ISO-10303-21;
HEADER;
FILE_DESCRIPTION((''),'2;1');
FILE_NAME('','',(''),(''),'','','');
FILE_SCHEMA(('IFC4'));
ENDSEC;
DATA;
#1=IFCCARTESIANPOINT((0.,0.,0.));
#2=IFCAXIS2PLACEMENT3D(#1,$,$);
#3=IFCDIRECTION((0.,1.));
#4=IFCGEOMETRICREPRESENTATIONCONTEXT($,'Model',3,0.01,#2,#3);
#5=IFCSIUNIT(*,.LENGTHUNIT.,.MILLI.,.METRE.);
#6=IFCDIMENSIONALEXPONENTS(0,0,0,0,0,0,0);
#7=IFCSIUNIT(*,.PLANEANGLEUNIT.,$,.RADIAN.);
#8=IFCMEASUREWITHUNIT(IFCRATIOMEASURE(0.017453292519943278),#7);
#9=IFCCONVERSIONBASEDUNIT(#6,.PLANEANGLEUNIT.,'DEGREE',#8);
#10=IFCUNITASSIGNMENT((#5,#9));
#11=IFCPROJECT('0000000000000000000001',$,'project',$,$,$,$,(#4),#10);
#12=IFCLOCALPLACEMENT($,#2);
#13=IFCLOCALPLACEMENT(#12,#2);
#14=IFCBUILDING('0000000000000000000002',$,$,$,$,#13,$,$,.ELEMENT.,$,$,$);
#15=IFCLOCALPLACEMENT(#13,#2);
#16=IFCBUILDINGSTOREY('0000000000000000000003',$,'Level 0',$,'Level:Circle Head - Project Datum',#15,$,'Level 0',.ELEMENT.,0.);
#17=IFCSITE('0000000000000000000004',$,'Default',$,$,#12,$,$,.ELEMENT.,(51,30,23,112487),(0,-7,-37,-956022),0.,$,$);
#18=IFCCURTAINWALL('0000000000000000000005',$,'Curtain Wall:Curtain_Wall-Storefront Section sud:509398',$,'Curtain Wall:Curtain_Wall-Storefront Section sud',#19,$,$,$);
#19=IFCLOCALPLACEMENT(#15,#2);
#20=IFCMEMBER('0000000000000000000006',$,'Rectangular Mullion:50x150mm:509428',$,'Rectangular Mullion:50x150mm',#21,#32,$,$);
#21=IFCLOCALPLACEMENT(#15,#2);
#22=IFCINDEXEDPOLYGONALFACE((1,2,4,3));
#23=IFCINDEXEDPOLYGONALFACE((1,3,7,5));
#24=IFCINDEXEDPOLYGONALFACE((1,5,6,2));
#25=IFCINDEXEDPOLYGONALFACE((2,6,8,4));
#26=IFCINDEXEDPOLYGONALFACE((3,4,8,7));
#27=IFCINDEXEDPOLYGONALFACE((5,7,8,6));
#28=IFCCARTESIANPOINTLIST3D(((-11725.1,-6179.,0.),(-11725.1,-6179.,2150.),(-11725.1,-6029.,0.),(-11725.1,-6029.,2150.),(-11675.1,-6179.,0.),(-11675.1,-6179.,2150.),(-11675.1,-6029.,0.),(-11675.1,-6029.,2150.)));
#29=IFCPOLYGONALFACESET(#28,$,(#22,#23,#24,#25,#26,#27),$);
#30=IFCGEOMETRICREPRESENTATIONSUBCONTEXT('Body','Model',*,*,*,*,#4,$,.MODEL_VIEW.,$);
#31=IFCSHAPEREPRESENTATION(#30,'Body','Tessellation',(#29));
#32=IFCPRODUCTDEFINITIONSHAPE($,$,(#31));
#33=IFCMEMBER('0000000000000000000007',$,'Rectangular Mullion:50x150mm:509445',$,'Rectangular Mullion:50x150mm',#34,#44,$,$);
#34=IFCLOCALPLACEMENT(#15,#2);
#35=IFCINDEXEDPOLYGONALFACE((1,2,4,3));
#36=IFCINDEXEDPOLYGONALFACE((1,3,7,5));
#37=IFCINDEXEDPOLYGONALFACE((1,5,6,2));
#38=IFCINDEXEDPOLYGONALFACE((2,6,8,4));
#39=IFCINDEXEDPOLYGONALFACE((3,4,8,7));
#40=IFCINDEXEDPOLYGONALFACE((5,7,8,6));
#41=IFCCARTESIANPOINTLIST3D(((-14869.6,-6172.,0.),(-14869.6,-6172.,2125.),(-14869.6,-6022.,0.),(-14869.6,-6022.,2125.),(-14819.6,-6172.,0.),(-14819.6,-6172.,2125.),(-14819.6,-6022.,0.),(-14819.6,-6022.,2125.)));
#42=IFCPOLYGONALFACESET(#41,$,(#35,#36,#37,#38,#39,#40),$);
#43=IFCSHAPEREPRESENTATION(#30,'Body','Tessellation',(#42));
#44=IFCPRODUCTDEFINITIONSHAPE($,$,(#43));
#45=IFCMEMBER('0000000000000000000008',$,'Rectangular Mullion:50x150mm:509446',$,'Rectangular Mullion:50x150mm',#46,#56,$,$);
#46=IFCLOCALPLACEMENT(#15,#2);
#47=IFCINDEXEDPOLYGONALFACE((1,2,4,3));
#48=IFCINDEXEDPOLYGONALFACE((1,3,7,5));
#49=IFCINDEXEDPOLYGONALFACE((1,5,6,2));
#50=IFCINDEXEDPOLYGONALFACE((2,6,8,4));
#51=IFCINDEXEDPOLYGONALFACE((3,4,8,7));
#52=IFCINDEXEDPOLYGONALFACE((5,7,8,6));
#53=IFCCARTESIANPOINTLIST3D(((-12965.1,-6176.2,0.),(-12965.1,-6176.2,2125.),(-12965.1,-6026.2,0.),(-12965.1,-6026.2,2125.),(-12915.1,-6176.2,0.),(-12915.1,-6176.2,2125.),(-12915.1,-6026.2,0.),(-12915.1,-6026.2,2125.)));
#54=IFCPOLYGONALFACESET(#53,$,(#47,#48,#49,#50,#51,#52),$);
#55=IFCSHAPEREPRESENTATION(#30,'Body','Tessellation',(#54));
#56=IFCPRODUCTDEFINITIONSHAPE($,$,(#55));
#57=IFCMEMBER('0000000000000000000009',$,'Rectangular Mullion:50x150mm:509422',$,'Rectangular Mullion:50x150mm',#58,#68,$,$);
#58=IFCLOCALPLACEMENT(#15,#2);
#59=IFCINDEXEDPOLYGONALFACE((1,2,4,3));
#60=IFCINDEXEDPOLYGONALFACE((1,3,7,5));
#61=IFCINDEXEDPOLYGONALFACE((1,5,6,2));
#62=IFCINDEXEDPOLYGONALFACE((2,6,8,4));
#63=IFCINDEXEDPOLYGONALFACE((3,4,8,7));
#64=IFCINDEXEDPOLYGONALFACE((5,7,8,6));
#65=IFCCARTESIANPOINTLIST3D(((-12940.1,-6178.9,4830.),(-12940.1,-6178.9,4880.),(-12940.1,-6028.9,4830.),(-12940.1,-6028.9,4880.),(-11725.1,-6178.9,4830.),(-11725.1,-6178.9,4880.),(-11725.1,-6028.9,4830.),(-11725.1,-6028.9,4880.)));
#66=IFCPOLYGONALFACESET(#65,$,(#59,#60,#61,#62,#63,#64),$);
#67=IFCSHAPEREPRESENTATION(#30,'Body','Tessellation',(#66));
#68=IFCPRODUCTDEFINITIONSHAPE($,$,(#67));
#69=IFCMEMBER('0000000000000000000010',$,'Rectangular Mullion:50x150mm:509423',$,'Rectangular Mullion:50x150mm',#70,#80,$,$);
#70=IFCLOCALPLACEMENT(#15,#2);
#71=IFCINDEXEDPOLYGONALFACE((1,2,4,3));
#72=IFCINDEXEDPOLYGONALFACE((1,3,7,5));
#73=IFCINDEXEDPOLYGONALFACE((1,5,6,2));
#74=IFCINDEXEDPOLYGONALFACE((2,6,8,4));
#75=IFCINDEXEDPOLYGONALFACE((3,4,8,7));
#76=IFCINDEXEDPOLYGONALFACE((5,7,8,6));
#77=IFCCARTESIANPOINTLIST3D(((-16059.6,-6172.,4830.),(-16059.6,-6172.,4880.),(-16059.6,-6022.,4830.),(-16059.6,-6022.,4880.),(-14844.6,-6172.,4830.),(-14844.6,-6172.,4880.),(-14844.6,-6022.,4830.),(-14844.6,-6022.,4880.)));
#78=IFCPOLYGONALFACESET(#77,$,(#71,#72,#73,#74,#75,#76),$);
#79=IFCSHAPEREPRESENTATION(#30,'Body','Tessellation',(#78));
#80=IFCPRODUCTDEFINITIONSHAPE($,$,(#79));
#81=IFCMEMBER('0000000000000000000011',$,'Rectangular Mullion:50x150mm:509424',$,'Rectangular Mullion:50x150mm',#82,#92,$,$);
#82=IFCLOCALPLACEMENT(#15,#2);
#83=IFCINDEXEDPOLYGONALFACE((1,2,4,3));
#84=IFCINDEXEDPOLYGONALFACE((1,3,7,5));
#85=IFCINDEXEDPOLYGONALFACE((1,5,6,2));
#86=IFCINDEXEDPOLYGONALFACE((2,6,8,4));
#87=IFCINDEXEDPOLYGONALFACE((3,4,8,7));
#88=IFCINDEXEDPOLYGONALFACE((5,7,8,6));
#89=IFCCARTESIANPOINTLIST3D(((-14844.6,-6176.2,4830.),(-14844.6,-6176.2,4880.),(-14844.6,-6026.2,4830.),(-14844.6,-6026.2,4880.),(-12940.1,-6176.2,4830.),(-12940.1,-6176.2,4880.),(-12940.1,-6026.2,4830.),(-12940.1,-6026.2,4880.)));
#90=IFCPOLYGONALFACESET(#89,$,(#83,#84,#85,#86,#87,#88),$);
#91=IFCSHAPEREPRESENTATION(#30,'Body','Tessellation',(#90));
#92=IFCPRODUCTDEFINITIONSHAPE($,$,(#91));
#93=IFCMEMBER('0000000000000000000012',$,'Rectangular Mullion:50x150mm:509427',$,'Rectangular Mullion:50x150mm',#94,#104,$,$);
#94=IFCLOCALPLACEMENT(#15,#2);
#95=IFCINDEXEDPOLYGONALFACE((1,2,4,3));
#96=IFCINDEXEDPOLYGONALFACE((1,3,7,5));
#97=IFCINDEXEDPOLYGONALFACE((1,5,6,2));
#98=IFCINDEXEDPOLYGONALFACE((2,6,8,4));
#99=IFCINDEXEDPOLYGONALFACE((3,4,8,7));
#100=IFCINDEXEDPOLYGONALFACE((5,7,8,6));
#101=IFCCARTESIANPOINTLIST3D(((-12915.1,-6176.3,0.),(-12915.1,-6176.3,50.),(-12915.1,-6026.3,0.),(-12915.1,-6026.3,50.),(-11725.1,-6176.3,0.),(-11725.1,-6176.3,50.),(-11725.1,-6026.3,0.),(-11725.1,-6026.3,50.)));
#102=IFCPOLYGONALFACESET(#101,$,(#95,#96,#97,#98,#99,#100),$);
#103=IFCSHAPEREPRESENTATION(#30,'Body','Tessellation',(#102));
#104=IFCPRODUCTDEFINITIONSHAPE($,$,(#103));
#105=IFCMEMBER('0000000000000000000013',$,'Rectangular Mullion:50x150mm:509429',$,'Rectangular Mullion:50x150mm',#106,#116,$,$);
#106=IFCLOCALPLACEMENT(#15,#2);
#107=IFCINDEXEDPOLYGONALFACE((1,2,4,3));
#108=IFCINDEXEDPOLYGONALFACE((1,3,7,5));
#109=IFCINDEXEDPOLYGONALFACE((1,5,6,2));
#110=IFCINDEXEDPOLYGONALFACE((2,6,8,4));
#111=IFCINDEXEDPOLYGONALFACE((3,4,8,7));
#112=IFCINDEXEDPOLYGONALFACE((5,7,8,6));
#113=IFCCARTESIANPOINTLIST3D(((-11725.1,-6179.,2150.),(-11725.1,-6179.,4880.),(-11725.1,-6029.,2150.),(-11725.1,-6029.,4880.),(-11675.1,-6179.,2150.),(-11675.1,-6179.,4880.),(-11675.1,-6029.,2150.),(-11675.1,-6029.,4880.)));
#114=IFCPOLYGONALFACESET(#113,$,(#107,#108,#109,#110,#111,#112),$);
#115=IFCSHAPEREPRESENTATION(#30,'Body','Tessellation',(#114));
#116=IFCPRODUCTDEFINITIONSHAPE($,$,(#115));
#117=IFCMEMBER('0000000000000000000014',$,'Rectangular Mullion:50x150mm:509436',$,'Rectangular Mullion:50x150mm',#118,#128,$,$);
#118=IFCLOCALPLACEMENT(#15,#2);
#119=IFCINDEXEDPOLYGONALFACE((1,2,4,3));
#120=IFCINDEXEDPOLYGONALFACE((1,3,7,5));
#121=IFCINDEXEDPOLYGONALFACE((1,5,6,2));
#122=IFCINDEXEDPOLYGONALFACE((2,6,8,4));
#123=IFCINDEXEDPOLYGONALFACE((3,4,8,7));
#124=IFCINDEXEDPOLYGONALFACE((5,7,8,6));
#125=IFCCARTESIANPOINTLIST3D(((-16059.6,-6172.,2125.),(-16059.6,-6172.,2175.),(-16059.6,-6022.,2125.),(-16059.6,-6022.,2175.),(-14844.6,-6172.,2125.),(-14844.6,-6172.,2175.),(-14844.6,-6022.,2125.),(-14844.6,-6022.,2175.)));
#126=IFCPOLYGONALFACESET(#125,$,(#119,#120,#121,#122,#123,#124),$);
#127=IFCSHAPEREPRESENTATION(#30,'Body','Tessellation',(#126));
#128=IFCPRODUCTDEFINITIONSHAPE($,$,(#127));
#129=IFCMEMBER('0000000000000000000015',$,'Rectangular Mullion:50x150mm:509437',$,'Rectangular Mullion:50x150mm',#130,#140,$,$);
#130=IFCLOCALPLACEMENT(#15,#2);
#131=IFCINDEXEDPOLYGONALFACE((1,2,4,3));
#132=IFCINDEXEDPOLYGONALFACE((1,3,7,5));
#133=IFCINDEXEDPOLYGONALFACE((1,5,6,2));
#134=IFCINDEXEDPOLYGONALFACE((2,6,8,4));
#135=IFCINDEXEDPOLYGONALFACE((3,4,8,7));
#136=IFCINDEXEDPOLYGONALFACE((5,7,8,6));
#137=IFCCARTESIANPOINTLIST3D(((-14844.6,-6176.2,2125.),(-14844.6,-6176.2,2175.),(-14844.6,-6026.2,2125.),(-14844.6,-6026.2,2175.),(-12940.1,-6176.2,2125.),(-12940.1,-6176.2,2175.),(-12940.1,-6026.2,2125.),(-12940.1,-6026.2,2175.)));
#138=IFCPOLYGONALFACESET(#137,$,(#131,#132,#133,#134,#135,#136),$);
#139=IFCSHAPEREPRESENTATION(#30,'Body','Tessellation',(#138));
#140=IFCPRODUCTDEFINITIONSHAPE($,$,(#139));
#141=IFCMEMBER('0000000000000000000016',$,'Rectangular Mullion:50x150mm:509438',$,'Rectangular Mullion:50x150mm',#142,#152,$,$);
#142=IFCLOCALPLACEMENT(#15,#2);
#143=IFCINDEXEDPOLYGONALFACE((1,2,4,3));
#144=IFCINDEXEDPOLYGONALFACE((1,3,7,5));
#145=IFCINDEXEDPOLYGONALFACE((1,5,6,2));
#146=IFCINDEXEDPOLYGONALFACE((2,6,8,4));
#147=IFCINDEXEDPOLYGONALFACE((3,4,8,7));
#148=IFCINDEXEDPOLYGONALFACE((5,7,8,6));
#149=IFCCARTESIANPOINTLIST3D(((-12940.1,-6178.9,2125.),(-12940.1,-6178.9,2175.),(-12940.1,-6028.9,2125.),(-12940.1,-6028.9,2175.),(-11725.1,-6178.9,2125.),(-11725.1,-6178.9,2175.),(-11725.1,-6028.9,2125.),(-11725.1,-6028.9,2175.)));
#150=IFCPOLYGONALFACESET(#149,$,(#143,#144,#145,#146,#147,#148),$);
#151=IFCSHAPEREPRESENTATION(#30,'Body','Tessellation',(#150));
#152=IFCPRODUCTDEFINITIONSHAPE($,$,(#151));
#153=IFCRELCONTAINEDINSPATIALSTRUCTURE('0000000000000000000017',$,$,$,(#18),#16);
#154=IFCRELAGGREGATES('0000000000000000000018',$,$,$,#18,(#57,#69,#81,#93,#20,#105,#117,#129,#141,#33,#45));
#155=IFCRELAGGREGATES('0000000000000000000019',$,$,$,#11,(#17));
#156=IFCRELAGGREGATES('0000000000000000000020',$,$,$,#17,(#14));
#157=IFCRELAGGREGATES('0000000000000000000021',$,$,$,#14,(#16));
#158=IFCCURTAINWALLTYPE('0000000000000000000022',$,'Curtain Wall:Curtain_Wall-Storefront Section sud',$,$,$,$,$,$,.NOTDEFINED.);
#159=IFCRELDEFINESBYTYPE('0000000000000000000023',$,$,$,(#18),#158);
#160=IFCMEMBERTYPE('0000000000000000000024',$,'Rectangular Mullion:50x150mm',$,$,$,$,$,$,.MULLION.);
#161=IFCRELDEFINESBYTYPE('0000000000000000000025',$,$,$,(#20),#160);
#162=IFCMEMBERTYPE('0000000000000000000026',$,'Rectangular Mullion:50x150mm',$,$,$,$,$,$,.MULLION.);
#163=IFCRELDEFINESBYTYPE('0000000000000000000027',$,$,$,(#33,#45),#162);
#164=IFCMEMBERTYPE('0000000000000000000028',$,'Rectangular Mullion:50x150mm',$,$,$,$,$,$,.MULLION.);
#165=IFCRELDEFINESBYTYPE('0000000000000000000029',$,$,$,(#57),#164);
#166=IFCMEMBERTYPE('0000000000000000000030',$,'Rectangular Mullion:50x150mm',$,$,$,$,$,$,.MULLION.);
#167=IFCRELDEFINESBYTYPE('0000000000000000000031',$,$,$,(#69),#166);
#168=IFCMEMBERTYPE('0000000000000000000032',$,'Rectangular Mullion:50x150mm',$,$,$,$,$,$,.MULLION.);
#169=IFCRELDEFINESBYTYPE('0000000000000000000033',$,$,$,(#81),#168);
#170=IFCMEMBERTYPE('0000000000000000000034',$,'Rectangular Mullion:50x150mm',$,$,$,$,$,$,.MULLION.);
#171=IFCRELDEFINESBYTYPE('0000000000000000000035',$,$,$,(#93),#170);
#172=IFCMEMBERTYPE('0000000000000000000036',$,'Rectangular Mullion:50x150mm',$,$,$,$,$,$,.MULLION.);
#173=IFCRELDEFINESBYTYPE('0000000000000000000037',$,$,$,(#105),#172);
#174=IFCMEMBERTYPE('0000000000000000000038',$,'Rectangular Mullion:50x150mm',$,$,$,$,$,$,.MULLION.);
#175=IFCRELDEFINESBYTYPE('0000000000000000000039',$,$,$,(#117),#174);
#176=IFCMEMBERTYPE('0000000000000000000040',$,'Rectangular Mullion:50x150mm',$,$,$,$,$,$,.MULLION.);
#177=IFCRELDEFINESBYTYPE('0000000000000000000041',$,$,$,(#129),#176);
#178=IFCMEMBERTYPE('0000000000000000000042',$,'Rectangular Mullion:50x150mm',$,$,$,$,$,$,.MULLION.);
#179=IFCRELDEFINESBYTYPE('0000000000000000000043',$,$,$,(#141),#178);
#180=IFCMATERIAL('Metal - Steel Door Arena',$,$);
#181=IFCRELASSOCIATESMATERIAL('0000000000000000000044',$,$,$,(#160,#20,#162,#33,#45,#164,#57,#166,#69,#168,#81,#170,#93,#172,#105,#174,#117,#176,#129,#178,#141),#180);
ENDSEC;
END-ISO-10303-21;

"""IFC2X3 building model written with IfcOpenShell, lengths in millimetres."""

from ifc_helpers import new_model, entity, si_unit, converted_unit, direction, frame, origin, origin_2d_with_axis, place, context, subcontext, project, spatial, rectangle, extrude, source, transform, mapped, material, type_object, type_shapes, element, aggregate, save


model = new_model("IFC2X3")

# Units and contexts
model_context = context("Model", 3, precision=0.01, world=origin(), true_north=direction((0.0, 1.0)))
body_context = subcontext(model_context, "Body", "Model", "MODEL_VIEW")
ifc_project = project(units=[si_unit("LENGTHUNIT", "METRE", prefix="MILLI"), converted_unit("PLANEANGLEUNIT", "DEGREE", entity("IfcRatioMeasure", 0.017453292519943278), si_unit("PLANEANGLEUNIT", "RADIAN"), dimensions=[0, 0, 0, 0, 0, 0, 0])], contexts=[model_context])

# Site, building, storey
site_placement = place(None, origin())
site = spatial("IfcSite", under=ifc_project, at=site_placement, Name="Default", CompositionType="ELEMENT", RefLatitude=(51, 30, 23, 112487), RefLongitude=(0, -7, -37, -956022), RefElevation=0.0)
building_placement = place(site_placement, origin())
building = spatial("IfcBuilding", under=site, at=building_placement, CompositionType="ELEMENT")
storey_placement = place(building_placement, origin())
storey = spatial("IfcBuildingStorey", under=building, at=storey_placement, Name="Level 0", ObjectType="Level:Circle Head - Project Datum", LongName="Level 0", CompositionType="ELEMENT", Elevation=0.0)

# Curtain wall, members
curtain_wall_type = type_object("IfcCurtainWallType", Name="Curtain Wall:Curtain_Wall-Storefront Section sud", PredefinedType="NOTDEFINED")
curtain_wall_placement = place(storey_placement, origin())
curtain_wall = element("IfcCurtainWall", 1, at=curtain_wall_placement, inside=storey, type_object=curtain_wall_type, Name="Curtain Wall:Curtain_Wall-Storefront Section sud:509398", ObjectType="Curtain Wall:Curtain_Wall-Storefront Section sud")
ifc_material_1 = material(Name="Metal - Steel Door Arena")
member_type_1 = type_object("IfcMemberType", Name="Rectangular Mullion:50x150mm", PredefinedType="MULLION", material=ifc_material_1)
shared_shape_1 = source(origin(), body_context, "Body", "SweptSolid", [
    extrude(rectangle(XDim=150.0, YDim=50.0, at=origin_2d_with_axis()), frame((-25.0, 0.0, -2150.0), z_axis=(0.0, 0.0, 1.0), x_axis=(0.0, -1.0, 0.0)), (0.0, 0.0, 1.0), 2150.0),
])
type_shapes(member_type_1, [shared_shape_1])
member_1_placement = place(curtain_wall_placement, frame((-11675.1, -6104.0, 0.0), z_axis=(0.0, 0.0, -1.0), x_axis=(1.0, 0.0, 0.0)))
member_1 = element("IfcMember", 2, at=member_1_placement, type_object=member_type_1, material=ifc_material_1, Name="Rectangular Mullion:50x150mm:509428", ObjectType="Rectangular Mullion:50x150mm", context=body_context, shape_type="MappedRepresentation", body=[
    mapped(shared_shape_1, transform((0.0, 0.0, 0.0), scale=1.0)),
])
member_type_2 = type_object("IfcMemberType", Name="Rectangular Mullion:50x150mm", PredefinedType="MULLION", material=ifc_material_1)
shared_shape_2 = source(origin(), body_context, "Body", "SweptSolid", [
    extrude(rectangle(XDim=150.0, YDim=50.0, at=origin_2d_with_axis()), frame((0.0, 0.0, -2125.0), z_axis=(0.0, 0.0, 1.0), x_axis=(0.0, -1.0, 0.0)), (0.0, 0.0, 1.0), 2125.0),
])
type_shapes(member_type_2, [shared_shape_2])
member_2_placement = place(curtain_wall_placement, frame((-14844.6, -6097.0, 0.0), z_axis=(0.0, 0.0, -1.0), x_axis=(1.0, 0.0, 0.0)))
member_2 = element("IfcMember", 3, at=member_2_placement, type_object=member_type_2, material=ifc_material_1, Name="Rectangular Mullion:50x150mm:509445", ObjectType="Rectangular Mullion:50x150mm", context=body_context, shape_type="MappedRepresentation", body=[
    mapped(shared_shape_2, transform((0.0, 0.0, 0.0), scale=1.0)),
])
member_3_placement = place(curtain_wall_placement, frame((-12940.1, -6101.2, 0.0), z_axis=(0.0, 0.0, -1.0), x_axis=(1.0, 0.0, 0.0)))
member_3 = element("IfcMember", 4, at=member_3_placement, type_object=member_type_2, material=ifc_material_1, Name="Rectangular Mullion:50x150mm:509446", ObjectType="Rectangular Mullion:50x150mm", context=body_context, shape_type="MappedRepresentation", body=[
    mapped(shared_shape_2, transform((0.0, 0.0, 0.0), scale=1.0)),
])
member_type_3 = type_object("IfcMemberType", Name="Rectangular Mullion:50x150mm", PredefinedType="MULLION", material=ifc_material_1)
shared_shape_3 = source(origin(), body_context, "Body", "SweptSolid", [
    extrude(rectangle(XDim=150.0, YDim=50.0, at=origin_2d_with_axis()), frame((-25.0, 0.0, -1215.0), z_axis=(0.0, 0.0, 1.0), x_axis=(0.0, -1.0, 0.0)), (0.0, 0.0, 1.0), 1215.0),
])
type_shapes(member_type_3, [shared_shape_3])
member_4_placement = place(curtain_wall_placement, frame((-11725.1, -6103.9, 4880.0), z_axis=(1.0, 0.0, 0.0), x_axis=(0.0, 0.0, 1.0)))
member_4 = element("IfcMember", 5, at=member_4_placement, type_object=member_type_3, material=ifc_material_1, Name="Rectangular Mullion:50x150mm:509422", ObjectType="Rectangular Mullion:50x150mm", context=body_context, shape_type="MappedRepresentation", body=[
    mapped(shared_shape_3, transform((0.0, 0.0, 0.0), scale=1.0)),
])
member_type_4 = type_object("IfcMemberType", Name="Rectangular Mullion:50x150mm", PredefinedType="MULLION", material=ifc_material_1)
shared_shape_4 = source(origin(), body_context, "Body", "SweptSolid", [
    extrude(rectangle(XDim=150.0, YDim=50.0, at=origin_2d_with_axis()), frame((-25.0, 0.0, -1215.0), z_axis=(0.0, 0.0, 1.0), x_axis=(0.0, -1.0, 0.0)), (0.0, 0.0, 1.0), 1215.0),
])
type_shapes(member_type_4, [shared_shape_4])
member_5_placement = place(curtain_wall_placement, frame((-14844.6, -6097.0, 4880.0), z_axis=(1.0, 0.0, 0.0), x_axis=(0.0, 0.0, 1.0)))
member_5 = element("IfcMember", 6, at=member_5_placement, type_object=member_type_4, material=ifc_material_1, Name="Rectangular Mullion:50x150mm:509423", ObjectType="Rectangular Mullion:50x150mm", context=body_context, shape_type="MappedRepresentation", body=[
    mapped(shared_shape_4, transform((0.0, 0.0, 0.0), scale=1.0)),
])
member_type_5 = type_object("IfcMemberType", Name="Rectangular Mullion:50x150mm", PredefinedType="MULLION", material=ifc_material_1)
shared_shape_5 = source(origin(), body_context, "Body", "SweptSolid", [
    extrude(rectangle(XDim=150.0, YDim=50.0, at=origin_2d_with_axis()), frame((-25.0, 0.0, -1904.5), z_axis=(0.0, 0.0, 1.0), x_axis=(0.0, -1.0, 0.0)), (0.0, 0.0, 1.0), 1904.5),
])
type_shapes(member_type_5, [shared_shape_5])
member_6_placement = place(curtain_wall_placement, frame((-12940.1, -6101.2, 4880.0), z_axis=(1.0, 0.0, 0.0), x_axis=(0.0, 0.0, 1.0)))
member_6 = element("IfcMember", 7, at=member_6_placement, type_object=member_type_5, material=ifc_material_1, Name="Rectangular Mullion:50x150mm:509424", ObjectType="Rectangular Mullion:50x150mm", context=body_context, shape_type="MappedRepresentation", body=[
    mapped(shared_shape_5, transform((0.0, 0.0, 0.0), scale=1.0)),
])
member_type_6 = type_object("IfcMemberType", Name="Rectangular Mullion:50x150mm", PredefinedType="MULLION", material=ifc_material_1)
shared_shape_6 = source(origin(), body_context, "Body", "SweptSolid", [
    extrude(rectangle(XDim=150.0, YDim=50.0, at=origin_2d_with_axis()), frame((-25.0, 0.0, -1190.0), z_axis=(0.0, 0.0, 1.0), x_axis=(0.0, -1.0, 0.0)), (0.0, 0.0, 1.0), 1190.0),
])
type_shapes(member_type_6, [shared_shape_6])
member_7_placement = place(curtain_wall_placement, frame((-12915.1, -6101.3, 0.0), z_axis=(-1.0, 0.0, 0.0), x_axis=(0.0, 0.0, -1.0)))
member_7 = element("IfcMember", 8, at=member_7_placement, type_object=member_type_6, material=ifc_material_1, Name="Rectangular Mullion:50x150mm:509427", ObjectType="Rectangular Mullion:50x150mm", context=body_context, shape_type="MappedRepresentation", body=[
    mapped(shared_shape_6, transform((0.0, 0.0, 0.0), scale=1.0)),
])
member_type_7 = type_object("IfcMemberType", Name="Rectangular Mullion:50x150mm", PredefinedType="MULLION", material=ifc_material_1)
shared_shape_7 = source(origin(), body_context, "Body", "SweptSolid", [
    extrude(rectangle(XDim=150.0, YDim=50.0, at=origin_2d_with_axis()), frame((-25.0, 0.0, -2730.0), z_axis=(0.0, 0.0, 1.0), x_axis=(0.0, -1.0, 0.0)), (0.0, 0.0, 1.0), 2730.0),
])
type_shapes(member_type_7, [shared_shape_7])
member_8_placement = place(curtain_wall_placement, frame((-11675.1, -6104.0, 2150.0), z_axis=(0.0, 0.0, -1.0), x_axis=(1.0, 0.0, 0.0)))
member_8 = element("IfcMember", 9, at=member_8_placement, type_object=member_type_7, material=ifc_material_1, Name="Rectangular Mullion:50x150mm:509429", ObjectType="Rectangular Mullion:50x150mm", context=body_context, shape_type="MappedRepresentation", body=[
    mapped(shared_shape_7, transform((0.0, 0.0, 0.0), scale=1.0)),
])
member_type_8 = type_object("IfcMemberType", Name="Rectangular Mullion:50x150mm", PredefinedType="MULLION", material=ifc_material_1)
shared_shape_8 = source(origin(), body_context, "Body", "SweptSolid", [
    extrude(rectangle(XDim=150.0, YDim=50.0, at=origin_2d_with_axis()), frame((0.0, 0.0, -1215.0), z_axis=(0.0, 0.0, 1.0), x_axis=(0.0, -1.0, 0.0)), (0.0, 0.0, 1.0), 1215.0),
])
type_shapes(member_type_8, [shared_shape_8])
member_9_placement = place(curtain_wall_placement, frame((-14844.6, -6097.0, 2150.0), z_axis=(1.0, 0.0, 0.0), x_axis=(0.0, 0.0, 1.0)))
member_9 = element("IfcMember", 10, at=member_9_placement, type_object=member_type_8, material=ifc_material_1, Name="Rectangular Mullion:50x150mm:509436", ObjectType="Rectangular Mullion:50x150mm", context=body_context, shape_type="MappedRepresentation", body=[
    mapped(shared_shape_8, transform((0.0, 0.0, 0.0), scale=1.0)),
])
member_type_9 = type_object("IfcMemberType", Name="Rectangular Mullion:50x150mm", PredefinedType="MULLION", material=ifc_material_1)
shared_shape_9 = source(origin(), body_context, "Body", "SweptSolid", [
    extrude(rectangle(XDim=150.0, YDim=50.0, at=origin_2d_with_axis()), frame((0.0, 0.0, -1904.5), z_axis=(0.0, 0.0, 1.0), x_axis=(0.0, -1.0, 0.0)), (0.0, 0.0, 1.0), 1904.5),
])
type_shapes(member_type_9, [shared_shape_9])
member_10_placement = place(curtain_wall_placement, frame((-12940.1, -6101.2, 2150.0), z_axis=(1.0, 0.0, 0.0), x_axis=(0.0, 0.0, 1.0)))
member_10 = element("IfcMember", 11, at=member_10_placement, type_object=member_type_9, material=ifc_material_1, Name="Rectangular Mullion:50x150mm:509437", ObjectType="Rectangular Mullion:50x150mm", context=body_context, shape_type="MappedRepresentation", body=[
    mapped(shared_shape_9, transform((0.0, 0.0, 0.0), scale=1.0)),
])
member_type_10 = type_object("IfcMemberType", Name="Rectangular Mullion:50x150mm", PredefinedType="MULLION", material=ifc_material_1)
shared_shape_10 = source(origin(), body_context, "Body", "SweptSolid", [
    extrude(rectangle(XDim=150.0, YDim=50.0, at=origin_2d_with_axis()), frame((0.0, 0.0, -1215.0), z_axis=(0.0, 0.0, 1.0), x_axis=(0.0, -1.0, 0.0)), (0.0, 0.0, 1.0), 1215.0),
])
type_shapes(member_type_10, [shared_shape_10])
member_11_placement = place(curtain_wall_placement, frame((-11725.1, -6103.9, 2150.0), z_axis=(1.0, 0.0, 0.0), x_axis=(0.0, 0.0, 1.0)))
member_11 = element("IfcMember", 12, at=member_11_placement, type_object=member_type_10, material=ifc_material_1, Name="Rectangular Mullion:50x150mm:509438", ObjectType="Rectangular Mullion:50x150mm", context=body_context, shape_type="MappedRepresentation", body=[
    mapped(shared_shape_10, transform((0.0, 0.0, 0.0), scale=1.0)),
])
aggregate(curtain_wall, [member_4, member_5, member_6, member_7, member_1, member_8, member_9, member_10, member_11, member_2, member_3])

save(model, "model.ifc")
